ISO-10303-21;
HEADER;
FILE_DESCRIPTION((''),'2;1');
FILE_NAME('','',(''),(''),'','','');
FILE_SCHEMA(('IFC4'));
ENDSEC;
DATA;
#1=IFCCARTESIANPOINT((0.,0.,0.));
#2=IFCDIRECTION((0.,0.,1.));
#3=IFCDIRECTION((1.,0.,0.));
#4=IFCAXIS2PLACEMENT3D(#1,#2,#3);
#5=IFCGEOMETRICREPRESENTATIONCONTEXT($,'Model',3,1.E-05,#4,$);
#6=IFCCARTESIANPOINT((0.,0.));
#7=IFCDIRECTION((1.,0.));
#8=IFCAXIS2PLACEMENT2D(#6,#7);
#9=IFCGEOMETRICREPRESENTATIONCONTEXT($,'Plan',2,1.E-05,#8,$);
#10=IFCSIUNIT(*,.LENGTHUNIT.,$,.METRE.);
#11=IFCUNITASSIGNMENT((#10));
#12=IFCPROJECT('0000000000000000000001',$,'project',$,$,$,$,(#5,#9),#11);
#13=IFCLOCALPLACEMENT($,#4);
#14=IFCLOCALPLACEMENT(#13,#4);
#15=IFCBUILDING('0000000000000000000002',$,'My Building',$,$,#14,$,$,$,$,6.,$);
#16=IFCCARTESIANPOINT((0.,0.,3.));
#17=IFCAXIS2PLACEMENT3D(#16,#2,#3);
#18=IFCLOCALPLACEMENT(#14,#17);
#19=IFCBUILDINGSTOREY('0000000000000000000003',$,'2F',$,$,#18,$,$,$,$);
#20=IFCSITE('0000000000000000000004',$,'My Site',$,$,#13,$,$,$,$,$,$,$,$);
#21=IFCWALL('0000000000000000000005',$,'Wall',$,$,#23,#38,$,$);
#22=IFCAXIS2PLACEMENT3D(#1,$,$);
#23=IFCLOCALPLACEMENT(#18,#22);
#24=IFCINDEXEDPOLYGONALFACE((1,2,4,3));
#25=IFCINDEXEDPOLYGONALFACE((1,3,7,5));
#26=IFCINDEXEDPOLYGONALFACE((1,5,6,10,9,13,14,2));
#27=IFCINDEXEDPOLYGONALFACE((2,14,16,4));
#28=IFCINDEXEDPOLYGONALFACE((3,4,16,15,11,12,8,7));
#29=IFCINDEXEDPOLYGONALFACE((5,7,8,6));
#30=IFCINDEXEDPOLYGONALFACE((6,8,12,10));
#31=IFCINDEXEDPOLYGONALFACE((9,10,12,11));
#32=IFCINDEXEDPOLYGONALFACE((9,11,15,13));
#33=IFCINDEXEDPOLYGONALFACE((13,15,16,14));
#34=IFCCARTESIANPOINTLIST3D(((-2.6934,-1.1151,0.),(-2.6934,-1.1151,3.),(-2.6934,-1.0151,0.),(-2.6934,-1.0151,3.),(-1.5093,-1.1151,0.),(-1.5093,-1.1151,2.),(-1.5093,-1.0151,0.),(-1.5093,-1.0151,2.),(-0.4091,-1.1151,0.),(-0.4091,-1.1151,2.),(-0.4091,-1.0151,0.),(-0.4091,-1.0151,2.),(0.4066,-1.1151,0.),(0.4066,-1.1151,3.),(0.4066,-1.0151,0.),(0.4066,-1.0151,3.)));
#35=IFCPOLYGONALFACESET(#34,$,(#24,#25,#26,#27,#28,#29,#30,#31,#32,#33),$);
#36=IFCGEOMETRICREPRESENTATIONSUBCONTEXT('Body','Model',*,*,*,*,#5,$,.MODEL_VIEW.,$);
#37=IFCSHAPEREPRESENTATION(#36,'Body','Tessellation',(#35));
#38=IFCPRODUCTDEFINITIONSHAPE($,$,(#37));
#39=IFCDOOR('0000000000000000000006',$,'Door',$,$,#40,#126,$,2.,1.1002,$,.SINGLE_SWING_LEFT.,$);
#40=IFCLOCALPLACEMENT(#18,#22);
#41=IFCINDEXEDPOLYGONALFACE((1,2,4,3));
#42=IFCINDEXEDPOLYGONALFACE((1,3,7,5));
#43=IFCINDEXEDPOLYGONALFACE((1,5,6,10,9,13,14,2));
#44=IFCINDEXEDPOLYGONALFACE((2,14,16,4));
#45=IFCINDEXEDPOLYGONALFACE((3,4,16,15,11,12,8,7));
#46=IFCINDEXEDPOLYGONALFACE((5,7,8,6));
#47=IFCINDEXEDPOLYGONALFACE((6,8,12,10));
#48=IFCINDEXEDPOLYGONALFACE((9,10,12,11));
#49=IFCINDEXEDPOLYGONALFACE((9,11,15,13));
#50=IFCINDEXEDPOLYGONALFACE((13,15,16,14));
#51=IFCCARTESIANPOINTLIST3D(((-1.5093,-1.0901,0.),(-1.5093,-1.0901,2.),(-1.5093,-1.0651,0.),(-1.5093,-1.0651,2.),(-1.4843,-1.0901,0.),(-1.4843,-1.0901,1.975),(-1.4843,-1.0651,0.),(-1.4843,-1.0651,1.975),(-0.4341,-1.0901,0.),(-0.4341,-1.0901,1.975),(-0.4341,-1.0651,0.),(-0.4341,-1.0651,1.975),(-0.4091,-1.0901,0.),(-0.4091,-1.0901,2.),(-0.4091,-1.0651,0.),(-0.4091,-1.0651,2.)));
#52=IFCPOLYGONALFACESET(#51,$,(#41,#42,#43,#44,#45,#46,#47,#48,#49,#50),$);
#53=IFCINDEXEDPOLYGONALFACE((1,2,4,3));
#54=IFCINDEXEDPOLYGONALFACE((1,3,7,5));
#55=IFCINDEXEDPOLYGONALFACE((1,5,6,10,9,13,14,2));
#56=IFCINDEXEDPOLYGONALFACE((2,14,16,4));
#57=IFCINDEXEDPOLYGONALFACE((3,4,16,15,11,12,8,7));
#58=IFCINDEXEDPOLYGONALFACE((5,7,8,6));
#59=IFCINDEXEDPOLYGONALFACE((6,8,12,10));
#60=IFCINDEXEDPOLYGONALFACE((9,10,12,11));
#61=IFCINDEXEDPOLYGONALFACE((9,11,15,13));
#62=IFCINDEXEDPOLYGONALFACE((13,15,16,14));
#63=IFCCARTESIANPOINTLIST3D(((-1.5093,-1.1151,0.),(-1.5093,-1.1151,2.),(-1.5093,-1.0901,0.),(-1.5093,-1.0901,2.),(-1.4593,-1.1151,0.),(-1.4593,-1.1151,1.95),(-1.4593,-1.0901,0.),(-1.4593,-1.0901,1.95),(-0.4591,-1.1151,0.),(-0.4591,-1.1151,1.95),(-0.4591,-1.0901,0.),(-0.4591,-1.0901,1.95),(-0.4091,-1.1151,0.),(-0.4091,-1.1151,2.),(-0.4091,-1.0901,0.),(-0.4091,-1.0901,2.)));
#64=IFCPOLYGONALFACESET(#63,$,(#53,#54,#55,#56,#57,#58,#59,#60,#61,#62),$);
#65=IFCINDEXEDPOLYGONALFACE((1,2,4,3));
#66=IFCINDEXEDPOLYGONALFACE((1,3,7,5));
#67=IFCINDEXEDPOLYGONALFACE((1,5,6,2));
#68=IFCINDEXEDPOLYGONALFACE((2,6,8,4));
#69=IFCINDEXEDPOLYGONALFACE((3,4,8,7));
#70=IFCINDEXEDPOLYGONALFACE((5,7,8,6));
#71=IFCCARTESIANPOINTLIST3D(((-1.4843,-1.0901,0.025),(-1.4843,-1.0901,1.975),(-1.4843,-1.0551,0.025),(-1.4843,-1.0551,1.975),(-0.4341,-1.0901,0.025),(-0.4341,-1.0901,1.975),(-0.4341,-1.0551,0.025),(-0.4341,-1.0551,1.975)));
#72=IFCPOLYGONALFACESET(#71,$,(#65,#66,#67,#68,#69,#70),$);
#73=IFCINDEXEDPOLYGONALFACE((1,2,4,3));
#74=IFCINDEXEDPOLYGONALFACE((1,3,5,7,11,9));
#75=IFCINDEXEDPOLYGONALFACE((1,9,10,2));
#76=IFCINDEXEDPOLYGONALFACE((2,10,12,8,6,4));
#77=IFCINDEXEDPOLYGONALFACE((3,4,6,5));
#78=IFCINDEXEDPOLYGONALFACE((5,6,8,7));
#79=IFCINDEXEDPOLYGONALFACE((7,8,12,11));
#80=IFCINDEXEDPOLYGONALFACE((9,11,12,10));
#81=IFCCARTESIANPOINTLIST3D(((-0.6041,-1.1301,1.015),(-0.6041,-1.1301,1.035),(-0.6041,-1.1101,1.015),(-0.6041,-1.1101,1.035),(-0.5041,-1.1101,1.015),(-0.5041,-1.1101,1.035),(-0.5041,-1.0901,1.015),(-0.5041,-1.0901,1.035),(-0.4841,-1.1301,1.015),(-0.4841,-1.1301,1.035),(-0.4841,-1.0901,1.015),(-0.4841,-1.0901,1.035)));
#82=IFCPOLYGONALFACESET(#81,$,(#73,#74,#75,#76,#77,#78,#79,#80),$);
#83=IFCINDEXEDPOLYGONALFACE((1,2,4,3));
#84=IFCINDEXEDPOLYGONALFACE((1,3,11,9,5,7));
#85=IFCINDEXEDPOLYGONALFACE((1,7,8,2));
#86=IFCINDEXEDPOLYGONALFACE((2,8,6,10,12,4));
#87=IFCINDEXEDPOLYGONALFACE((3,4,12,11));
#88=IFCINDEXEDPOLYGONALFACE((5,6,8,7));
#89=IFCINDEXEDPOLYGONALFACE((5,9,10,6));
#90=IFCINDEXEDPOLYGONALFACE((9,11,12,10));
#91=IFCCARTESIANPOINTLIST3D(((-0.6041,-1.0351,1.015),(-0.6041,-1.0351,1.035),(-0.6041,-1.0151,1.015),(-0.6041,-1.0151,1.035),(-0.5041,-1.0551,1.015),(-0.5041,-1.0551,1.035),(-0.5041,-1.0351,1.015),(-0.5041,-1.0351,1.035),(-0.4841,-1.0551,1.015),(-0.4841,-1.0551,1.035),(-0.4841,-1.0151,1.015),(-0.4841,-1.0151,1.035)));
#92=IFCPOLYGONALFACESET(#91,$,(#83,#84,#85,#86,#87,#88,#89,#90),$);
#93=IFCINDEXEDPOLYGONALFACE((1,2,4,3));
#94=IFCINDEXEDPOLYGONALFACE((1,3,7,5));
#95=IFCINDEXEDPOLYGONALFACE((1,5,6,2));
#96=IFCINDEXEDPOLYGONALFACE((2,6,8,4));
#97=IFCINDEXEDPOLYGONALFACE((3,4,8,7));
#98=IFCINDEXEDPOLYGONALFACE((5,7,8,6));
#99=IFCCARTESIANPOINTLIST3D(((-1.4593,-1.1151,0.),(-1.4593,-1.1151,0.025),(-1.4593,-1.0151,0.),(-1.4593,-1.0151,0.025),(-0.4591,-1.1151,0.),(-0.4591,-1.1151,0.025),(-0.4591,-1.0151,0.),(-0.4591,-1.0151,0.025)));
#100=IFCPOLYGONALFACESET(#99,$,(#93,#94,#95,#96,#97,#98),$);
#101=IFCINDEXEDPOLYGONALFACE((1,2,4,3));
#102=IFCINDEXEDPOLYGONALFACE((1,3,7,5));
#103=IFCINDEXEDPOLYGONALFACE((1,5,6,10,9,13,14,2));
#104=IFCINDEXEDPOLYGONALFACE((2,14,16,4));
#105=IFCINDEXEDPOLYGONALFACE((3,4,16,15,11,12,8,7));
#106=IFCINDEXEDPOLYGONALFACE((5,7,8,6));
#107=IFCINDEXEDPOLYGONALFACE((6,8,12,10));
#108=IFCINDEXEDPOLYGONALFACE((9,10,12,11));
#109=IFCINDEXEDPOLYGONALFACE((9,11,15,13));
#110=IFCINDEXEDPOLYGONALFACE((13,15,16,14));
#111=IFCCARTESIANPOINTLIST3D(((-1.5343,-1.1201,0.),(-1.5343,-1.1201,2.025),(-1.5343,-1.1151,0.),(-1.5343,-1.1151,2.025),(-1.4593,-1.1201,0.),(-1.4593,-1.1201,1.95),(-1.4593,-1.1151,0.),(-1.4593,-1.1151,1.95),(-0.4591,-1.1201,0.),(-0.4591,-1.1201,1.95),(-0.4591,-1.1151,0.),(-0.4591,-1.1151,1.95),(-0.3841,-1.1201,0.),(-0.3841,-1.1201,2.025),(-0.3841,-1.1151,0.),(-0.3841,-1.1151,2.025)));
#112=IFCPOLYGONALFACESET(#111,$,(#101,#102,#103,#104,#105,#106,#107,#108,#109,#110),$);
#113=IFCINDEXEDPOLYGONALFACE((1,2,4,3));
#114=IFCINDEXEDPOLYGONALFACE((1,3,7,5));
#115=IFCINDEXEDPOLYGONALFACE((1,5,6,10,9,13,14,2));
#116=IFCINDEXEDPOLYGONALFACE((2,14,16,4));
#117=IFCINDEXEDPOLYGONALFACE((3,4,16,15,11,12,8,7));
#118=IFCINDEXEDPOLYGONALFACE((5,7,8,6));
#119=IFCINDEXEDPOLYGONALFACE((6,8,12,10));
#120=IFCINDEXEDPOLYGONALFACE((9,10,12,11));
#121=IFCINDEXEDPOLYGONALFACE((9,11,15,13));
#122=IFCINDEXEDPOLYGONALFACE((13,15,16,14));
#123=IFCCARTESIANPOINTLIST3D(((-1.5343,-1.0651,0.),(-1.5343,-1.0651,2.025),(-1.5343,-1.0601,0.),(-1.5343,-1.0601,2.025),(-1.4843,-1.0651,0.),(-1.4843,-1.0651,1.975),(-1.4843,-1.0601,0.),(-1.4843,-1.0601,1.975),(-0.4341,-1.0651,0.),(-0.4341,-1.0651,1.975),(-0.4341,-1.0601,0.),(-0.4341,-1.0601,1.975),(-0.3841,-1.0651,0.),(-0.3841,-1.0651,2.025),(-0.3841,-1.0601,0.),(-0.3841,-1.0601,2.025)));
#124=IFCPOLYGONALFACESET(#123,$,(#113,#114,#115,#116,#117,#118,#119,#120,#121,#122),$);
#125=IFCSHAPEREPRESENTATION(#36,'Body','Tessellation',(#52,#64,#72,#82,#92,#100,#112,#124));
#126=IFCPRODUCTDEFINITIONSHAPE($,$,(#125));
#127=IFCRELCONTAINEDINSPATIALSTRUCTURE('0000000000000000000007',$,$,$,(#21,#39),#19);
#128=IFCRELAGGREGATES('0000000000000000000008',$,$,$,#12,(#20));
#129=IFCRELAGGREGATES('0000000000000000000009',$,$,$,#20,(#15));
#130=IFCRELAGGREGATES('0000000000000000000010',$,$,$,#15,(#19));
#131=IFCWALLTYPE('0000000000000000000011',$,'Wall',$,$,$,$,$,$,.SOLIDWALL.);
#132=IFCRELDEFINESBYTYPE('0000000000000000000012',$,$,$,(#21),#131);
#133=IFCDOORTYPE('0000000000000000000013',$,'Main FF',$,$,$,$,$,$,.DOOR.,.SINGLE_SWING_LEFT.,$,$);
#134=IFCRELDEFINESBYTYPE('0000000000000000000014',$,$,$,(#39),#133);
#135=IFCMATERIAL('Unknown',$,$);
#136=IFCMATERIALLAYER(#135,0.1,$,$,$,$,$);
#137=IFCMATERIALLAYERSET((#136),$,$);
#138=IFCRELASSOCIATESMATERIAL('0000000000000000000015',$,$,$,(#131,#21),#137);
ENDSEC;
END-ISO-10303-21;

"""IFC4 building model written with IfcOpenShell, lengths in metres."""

from ifc_helpers import new_model, entity, si_unit, frame, origin_with_axes, origin_2d_with_axis, place, context, subcontext, project, spatial, line, indexed_curve, outline, extrude, shape, source, transform, mapped, material, layer, layer_set, layer_usage, type_object, type_shapes, element, fill, save


model = new_model("IFC4")

# Units and contexts
model_context = context("Model", 3, precision=1e-05, world=origin_with_axes())
plan_context = context("Plan", 2, precision=1e-05, world=origin_2d_with_axis())
body_context_1 = subcontext(model_context, "Body", "Model", "MODEL_VIEW")
body_context_2 = subcontext(plan_context, "Body", "Plan", "PLAN_VIEW")
ifc_project = project(units=[si_unit("LENGTHUNIT", "METRE")], contexts=[model_context, plan_context])

# Site, building, storey
site_placement = place(None, origin_with_axes())
site = spatial("IfcSite", under=ifc_project, at=site_placement, Name="My Site")
building_placement = place(site_placement, origin_with_axes())
building = spatial("IfcBuilding", under=site, at=building_placement, Name="My Building", ElevationOfTerrain=6.0)
storey_placement = place(building_placement, frame((0.0, 0.0, 3.0), z_axis=(0.0, 0.0, 1.0), x_axis=(1.0, 0.0, 0.0)))
storey = spatial("IfcBuildingStorey", under=building, at=storey_placement, Name="2F")

# Shared definitions
ifc_material = material(Name="Unknown")

# Shared definitions
ifc_layer_1 = layer(ifc_material, 0.1)
ifc_layer_set_1 = layer_set([ifc_layer_1])
wall_type = type_object("IfcWallType", Name="Wall", PredefinedType="SOLIDWALL", material=ifc_layer_set_1)

# Wall, opening, door
ifc_layer_usage_1 = layer_usage(ifc_layer_set_1, "AXIS2", "POSITIVE", 0.0)
wall_1_placement = place(storey_placement, frame((-2.6934, -1.1151, 0.0), z_axis=(0.0, 0.0, 1.0), x_axis=(1.0, 0.0, 0.0)))
wall_1 = element("IfcWall", 1, at=wall_1_placement, inside=storey, type_object=wall_type, material=ifc_layer_usage_1, Name="Wall", context=body_context_1, shape_type="SweptSolid", body=[
    extrude(outline(indexed_curve([(0.0, 0.0), (0.0, 0.1), (3.1, 0.1), (3.1, 0.0)], segments=[line(1, 2, 3, 4, 1)])), origin_with_axes(), (0.0, 0.0, 1.0), 3.0),
])
shared_shape_1 = source(origin_with_axes(), body_context_1, "Body", "SweptSolid", [
    extrude(outline(indexed_curve([(0.0, 0.0), (1.1002, 0.0), (1.1002, 2.0), (0.0, 2.0)], segments=[line(1, 2, 3, 4, 1)])), frame((0.0, -0.6, 0.0), z_axis=(0.0, -1.0, 0.0), x_axis=(1.0, 0.0, 0.0)), (0.0, 0.0, -1.0), 1.2),
])
opening_1_placement = place(wall_1_placement, frame((1.1841, 0.0, 0.0), z_axis=(0.0, 0.0, 1.0), x_axis=(1.0, 0.0, 0.0)))
opening_1 = element("IfcOpeningElement", 2, at=opening_1_placement, cuts=wall_1, PredefinedType="OPENING", context=body_context_1, shape_type="MappedRepresentation", body=[
    mapped(shared_shape_1, transform((0.0, 0.0, 0.0), x_axis=(1.0, 0.0, 0.0), y_axis=(0.0, 1.0, 0.0), z_axis=(0.0, 0.0, 1.0), scale=1.0)),
])
door_type_1 = type_object("IfcDoorType", Name="Main FF", OperationType="SINGLE_SWING_LEFT", PredefinedType="DOOR")
shared_shape_2 = source(origin_with_axes(), body_context_1, "Body", "SweptSolid", [
    extrude(outline(indexed_curve([(0.0, 0.0), (0.0, 2.0), (1.1002, 2.0), (1.1002, 0.0), (1.0752, 0.0), (1.0752, 1.975), (0.025, 1.975), (0.025, 0.0)], segments=[line(1, 2, 3, 4, 5, 6, 7, 8, 1)])), frame((0.0, 0.025, 0.0), z_axis=(0.0, -1.0, 0.0), x_axis=(1.0, 0.0, 0.0)), (0.0, 0.0, -1.0), 0.025),
    extrude(outline(indexed_curve([(0.0, 0.0), (0.0, 2.0), (1.1002, 2.0), (1.1002, 0.0), (1.0502, 0.0), (1.0502, 1.95), (0.05, 1.95), (0.05, 0.0)], segments=[line(1, 2, 3, 4, 5, 6, 7, 8, 1)])), frame((0.0, 0.0, 0.0), z_axis=(0.0, -1.0, 0.0), x_axis=(1.0, 0.0, 0.0)), (0.0, 0.0, -1.0), 0.025),
    extrude(outline(indexed_curve([(0.0, 0.0), (1.0502, 0.0), (1.0502, 0.035), (0.0, 0.035)], segments=[line(1, 2, 3, 4, 1)])), frame((0.025, 0.025, 0.025), z_axis=(0.0, 0.0, 1.0), x_axis=(1.0, 0.0, 0.0)), (0.0, 0.0, 1.0), 1.95),
    extrude(outline(indexed_curve([(0.0, 0.0), (0.0, -0.04), (-0.12, -0.04), (-0.12, -0.02), (-0.02, -0.02), (-0.02, 0.0)], segments=[line(1, 2, 3, 4, 5, 6, 1)])), frame((1.0252, 0.025, 1.015), z_axis=(0.0, 0.0, 1.0), x_axis=(1.0, 0.0, 0.0)), (0.0, 0.0, 1.0), 0.02),
    extrude(outline(indexed_curve([(0.0, 0.0), (0.0, 0.04), (-0.12, 0.04), (-0.12, 0.02), (-0.02, 0.02), (-0.02, 0.0)], segments=[line(1, 2, 3, 4, 5, 6, 1)])), frame((1.0252, 0.06, 1.015), z_axis=(0.0, 0.0, 1.0), x_axis=(1.0, 0.0, 0.0)), (0.0, 0.0, 1.0), 0.02),
    extrude(outline(indexed_curve([(0.0, 0.0), (1.0002, 0.0), (1.0002, 0.1), (0.0, 0.1)], segments=[line(1, 2, 3, 4, 1)])), frame((0.05, 0.0, 0.0), z_axis=(0.0, 0.0, 1.0), x_axis=(1.0, 0.0, 0.0)), (0.0, 0.0, 1.0), 0.025),
    extrude(outline(indexed_curve([(0.0, 0.0), (0.0, 2.025), (1.1502, 2.025), (1.1502, 0.0), (1.0752, 0.0), (1.0752, 1.95), (0.075, 1.95), (0.075, 0.0)], segments=[line(1, 2, 3, 4, 5, 6, 7, 8, 1)])), frame((-0.025, -0.005, 0.0), z_axis=(0.0, -1.0, 0.0), x_axis=(1.0, 0.0, 0.0)), (0.0, 0.0, -1.0), 0.005),
    extrude(outline(indexed_curve([(0.0, 0.0), (0.0, 2.025), (1.1502, 2.025), (1.1502, 0.0), (1.1002, 0.0), (1.1002, 1.975), (0.05, 1.975), (0.05, 0.0)], segments=[line(1, 2, 3, 4, 5, 6, 7, 8, 1)])), frame((-0.025, 0.05, 0.0), z_axis=(0.0, -1.0, 0.0), x_axis=(1.0, 0.0, 0.0)), (0.0, 0.0, -1.0), 0.005),
])
shared_shape_3 = source(origin_with_axes(), body_context_2, "Body", "Curve2D", [
    entity("IfcIndexedPolyCurve", entity("IfcCartesianPointList2D", [[0.0, 0.0], [0.0, 0.05], [0.025, 0.05], [0.025, 0.025], [0.05, 0.025], [0.05, 0.0]]), [entity("IfcLineIndex", [1, 2, 3, 4, 5, 6, 1])]),
    entity("IfcIndexedPolyCurve", entity("IfcCartesianPointList2D", [[1.1002, 0.0], [1.1002, 0.05], [1.0752, 0.05], [1.0752, 0.025], [1.0502, 0.025], [1.0502, 0.0]]), [entity("IfcLineIndex", [1, 2, 3, 4, 5, 6, 1])]),
    entity("IfcTrimmedCurve", entity("IfcEllipse", entity("IfcAxis2Placement2D", entity("IfcCartesianPoint", [0.06, 0.05]), entity("IfcDirection", [1.0, 0.0])), 1.0152, 1.0502), [entity("IfcCartesianPoint", [1.0752, 0.05])], [entity("IfcCartesianPoint", [0.06, 1.1002])], True, "CARTESIAN"),
    entity("IfcIndexedPolyCurve", entity("IfcCartesianPointList2D", [[0.025, 0.05], [0.06, 0.05], [0.06, 1.1002], [0.025, 1.1002]]), [entity("IfcLineIndex", [1, 2, 3, 4, 1])]),
])
type_shapes(door_type_1, [shared_shape_2, shared_shape_3])
door_1_placement = place(opening_1_placement, origin_with_axes())
door_1 = element("IfcDoor", 3, at=door_1_placement, inside=storey, type_object=door_type_1, Name="Door", OperationType="SINGLE_SWING_LEFT", OverallHeight=2.0, OverallWidth=1.1002, shapes=[
    shape(body_context_1, "Body", "MappedRepresentation", [mapped(shared_shape_2, transform((0.0, 0.0, 0.0), x_axis=(1.0, 0.0, 0.0), y_axis=(0.0, 1.0, 0.0), z_axis=(0.0, 0.0, 1.0), scale=1.0))]),
    shape(body_context_2, "Body", "MappedRepresentation", [mapped(shared_shape_3, transform((0.0, 0.0, 0.0), x_axis=(1.0, 0.0, 0.0), y_axis=(0.0, 1.0, 0.0), z_axis=(0.0, 0.0, 1.0), scale=1.0))]),
])
fill(opening_1, door_1)

save(model, "model.ifc")
